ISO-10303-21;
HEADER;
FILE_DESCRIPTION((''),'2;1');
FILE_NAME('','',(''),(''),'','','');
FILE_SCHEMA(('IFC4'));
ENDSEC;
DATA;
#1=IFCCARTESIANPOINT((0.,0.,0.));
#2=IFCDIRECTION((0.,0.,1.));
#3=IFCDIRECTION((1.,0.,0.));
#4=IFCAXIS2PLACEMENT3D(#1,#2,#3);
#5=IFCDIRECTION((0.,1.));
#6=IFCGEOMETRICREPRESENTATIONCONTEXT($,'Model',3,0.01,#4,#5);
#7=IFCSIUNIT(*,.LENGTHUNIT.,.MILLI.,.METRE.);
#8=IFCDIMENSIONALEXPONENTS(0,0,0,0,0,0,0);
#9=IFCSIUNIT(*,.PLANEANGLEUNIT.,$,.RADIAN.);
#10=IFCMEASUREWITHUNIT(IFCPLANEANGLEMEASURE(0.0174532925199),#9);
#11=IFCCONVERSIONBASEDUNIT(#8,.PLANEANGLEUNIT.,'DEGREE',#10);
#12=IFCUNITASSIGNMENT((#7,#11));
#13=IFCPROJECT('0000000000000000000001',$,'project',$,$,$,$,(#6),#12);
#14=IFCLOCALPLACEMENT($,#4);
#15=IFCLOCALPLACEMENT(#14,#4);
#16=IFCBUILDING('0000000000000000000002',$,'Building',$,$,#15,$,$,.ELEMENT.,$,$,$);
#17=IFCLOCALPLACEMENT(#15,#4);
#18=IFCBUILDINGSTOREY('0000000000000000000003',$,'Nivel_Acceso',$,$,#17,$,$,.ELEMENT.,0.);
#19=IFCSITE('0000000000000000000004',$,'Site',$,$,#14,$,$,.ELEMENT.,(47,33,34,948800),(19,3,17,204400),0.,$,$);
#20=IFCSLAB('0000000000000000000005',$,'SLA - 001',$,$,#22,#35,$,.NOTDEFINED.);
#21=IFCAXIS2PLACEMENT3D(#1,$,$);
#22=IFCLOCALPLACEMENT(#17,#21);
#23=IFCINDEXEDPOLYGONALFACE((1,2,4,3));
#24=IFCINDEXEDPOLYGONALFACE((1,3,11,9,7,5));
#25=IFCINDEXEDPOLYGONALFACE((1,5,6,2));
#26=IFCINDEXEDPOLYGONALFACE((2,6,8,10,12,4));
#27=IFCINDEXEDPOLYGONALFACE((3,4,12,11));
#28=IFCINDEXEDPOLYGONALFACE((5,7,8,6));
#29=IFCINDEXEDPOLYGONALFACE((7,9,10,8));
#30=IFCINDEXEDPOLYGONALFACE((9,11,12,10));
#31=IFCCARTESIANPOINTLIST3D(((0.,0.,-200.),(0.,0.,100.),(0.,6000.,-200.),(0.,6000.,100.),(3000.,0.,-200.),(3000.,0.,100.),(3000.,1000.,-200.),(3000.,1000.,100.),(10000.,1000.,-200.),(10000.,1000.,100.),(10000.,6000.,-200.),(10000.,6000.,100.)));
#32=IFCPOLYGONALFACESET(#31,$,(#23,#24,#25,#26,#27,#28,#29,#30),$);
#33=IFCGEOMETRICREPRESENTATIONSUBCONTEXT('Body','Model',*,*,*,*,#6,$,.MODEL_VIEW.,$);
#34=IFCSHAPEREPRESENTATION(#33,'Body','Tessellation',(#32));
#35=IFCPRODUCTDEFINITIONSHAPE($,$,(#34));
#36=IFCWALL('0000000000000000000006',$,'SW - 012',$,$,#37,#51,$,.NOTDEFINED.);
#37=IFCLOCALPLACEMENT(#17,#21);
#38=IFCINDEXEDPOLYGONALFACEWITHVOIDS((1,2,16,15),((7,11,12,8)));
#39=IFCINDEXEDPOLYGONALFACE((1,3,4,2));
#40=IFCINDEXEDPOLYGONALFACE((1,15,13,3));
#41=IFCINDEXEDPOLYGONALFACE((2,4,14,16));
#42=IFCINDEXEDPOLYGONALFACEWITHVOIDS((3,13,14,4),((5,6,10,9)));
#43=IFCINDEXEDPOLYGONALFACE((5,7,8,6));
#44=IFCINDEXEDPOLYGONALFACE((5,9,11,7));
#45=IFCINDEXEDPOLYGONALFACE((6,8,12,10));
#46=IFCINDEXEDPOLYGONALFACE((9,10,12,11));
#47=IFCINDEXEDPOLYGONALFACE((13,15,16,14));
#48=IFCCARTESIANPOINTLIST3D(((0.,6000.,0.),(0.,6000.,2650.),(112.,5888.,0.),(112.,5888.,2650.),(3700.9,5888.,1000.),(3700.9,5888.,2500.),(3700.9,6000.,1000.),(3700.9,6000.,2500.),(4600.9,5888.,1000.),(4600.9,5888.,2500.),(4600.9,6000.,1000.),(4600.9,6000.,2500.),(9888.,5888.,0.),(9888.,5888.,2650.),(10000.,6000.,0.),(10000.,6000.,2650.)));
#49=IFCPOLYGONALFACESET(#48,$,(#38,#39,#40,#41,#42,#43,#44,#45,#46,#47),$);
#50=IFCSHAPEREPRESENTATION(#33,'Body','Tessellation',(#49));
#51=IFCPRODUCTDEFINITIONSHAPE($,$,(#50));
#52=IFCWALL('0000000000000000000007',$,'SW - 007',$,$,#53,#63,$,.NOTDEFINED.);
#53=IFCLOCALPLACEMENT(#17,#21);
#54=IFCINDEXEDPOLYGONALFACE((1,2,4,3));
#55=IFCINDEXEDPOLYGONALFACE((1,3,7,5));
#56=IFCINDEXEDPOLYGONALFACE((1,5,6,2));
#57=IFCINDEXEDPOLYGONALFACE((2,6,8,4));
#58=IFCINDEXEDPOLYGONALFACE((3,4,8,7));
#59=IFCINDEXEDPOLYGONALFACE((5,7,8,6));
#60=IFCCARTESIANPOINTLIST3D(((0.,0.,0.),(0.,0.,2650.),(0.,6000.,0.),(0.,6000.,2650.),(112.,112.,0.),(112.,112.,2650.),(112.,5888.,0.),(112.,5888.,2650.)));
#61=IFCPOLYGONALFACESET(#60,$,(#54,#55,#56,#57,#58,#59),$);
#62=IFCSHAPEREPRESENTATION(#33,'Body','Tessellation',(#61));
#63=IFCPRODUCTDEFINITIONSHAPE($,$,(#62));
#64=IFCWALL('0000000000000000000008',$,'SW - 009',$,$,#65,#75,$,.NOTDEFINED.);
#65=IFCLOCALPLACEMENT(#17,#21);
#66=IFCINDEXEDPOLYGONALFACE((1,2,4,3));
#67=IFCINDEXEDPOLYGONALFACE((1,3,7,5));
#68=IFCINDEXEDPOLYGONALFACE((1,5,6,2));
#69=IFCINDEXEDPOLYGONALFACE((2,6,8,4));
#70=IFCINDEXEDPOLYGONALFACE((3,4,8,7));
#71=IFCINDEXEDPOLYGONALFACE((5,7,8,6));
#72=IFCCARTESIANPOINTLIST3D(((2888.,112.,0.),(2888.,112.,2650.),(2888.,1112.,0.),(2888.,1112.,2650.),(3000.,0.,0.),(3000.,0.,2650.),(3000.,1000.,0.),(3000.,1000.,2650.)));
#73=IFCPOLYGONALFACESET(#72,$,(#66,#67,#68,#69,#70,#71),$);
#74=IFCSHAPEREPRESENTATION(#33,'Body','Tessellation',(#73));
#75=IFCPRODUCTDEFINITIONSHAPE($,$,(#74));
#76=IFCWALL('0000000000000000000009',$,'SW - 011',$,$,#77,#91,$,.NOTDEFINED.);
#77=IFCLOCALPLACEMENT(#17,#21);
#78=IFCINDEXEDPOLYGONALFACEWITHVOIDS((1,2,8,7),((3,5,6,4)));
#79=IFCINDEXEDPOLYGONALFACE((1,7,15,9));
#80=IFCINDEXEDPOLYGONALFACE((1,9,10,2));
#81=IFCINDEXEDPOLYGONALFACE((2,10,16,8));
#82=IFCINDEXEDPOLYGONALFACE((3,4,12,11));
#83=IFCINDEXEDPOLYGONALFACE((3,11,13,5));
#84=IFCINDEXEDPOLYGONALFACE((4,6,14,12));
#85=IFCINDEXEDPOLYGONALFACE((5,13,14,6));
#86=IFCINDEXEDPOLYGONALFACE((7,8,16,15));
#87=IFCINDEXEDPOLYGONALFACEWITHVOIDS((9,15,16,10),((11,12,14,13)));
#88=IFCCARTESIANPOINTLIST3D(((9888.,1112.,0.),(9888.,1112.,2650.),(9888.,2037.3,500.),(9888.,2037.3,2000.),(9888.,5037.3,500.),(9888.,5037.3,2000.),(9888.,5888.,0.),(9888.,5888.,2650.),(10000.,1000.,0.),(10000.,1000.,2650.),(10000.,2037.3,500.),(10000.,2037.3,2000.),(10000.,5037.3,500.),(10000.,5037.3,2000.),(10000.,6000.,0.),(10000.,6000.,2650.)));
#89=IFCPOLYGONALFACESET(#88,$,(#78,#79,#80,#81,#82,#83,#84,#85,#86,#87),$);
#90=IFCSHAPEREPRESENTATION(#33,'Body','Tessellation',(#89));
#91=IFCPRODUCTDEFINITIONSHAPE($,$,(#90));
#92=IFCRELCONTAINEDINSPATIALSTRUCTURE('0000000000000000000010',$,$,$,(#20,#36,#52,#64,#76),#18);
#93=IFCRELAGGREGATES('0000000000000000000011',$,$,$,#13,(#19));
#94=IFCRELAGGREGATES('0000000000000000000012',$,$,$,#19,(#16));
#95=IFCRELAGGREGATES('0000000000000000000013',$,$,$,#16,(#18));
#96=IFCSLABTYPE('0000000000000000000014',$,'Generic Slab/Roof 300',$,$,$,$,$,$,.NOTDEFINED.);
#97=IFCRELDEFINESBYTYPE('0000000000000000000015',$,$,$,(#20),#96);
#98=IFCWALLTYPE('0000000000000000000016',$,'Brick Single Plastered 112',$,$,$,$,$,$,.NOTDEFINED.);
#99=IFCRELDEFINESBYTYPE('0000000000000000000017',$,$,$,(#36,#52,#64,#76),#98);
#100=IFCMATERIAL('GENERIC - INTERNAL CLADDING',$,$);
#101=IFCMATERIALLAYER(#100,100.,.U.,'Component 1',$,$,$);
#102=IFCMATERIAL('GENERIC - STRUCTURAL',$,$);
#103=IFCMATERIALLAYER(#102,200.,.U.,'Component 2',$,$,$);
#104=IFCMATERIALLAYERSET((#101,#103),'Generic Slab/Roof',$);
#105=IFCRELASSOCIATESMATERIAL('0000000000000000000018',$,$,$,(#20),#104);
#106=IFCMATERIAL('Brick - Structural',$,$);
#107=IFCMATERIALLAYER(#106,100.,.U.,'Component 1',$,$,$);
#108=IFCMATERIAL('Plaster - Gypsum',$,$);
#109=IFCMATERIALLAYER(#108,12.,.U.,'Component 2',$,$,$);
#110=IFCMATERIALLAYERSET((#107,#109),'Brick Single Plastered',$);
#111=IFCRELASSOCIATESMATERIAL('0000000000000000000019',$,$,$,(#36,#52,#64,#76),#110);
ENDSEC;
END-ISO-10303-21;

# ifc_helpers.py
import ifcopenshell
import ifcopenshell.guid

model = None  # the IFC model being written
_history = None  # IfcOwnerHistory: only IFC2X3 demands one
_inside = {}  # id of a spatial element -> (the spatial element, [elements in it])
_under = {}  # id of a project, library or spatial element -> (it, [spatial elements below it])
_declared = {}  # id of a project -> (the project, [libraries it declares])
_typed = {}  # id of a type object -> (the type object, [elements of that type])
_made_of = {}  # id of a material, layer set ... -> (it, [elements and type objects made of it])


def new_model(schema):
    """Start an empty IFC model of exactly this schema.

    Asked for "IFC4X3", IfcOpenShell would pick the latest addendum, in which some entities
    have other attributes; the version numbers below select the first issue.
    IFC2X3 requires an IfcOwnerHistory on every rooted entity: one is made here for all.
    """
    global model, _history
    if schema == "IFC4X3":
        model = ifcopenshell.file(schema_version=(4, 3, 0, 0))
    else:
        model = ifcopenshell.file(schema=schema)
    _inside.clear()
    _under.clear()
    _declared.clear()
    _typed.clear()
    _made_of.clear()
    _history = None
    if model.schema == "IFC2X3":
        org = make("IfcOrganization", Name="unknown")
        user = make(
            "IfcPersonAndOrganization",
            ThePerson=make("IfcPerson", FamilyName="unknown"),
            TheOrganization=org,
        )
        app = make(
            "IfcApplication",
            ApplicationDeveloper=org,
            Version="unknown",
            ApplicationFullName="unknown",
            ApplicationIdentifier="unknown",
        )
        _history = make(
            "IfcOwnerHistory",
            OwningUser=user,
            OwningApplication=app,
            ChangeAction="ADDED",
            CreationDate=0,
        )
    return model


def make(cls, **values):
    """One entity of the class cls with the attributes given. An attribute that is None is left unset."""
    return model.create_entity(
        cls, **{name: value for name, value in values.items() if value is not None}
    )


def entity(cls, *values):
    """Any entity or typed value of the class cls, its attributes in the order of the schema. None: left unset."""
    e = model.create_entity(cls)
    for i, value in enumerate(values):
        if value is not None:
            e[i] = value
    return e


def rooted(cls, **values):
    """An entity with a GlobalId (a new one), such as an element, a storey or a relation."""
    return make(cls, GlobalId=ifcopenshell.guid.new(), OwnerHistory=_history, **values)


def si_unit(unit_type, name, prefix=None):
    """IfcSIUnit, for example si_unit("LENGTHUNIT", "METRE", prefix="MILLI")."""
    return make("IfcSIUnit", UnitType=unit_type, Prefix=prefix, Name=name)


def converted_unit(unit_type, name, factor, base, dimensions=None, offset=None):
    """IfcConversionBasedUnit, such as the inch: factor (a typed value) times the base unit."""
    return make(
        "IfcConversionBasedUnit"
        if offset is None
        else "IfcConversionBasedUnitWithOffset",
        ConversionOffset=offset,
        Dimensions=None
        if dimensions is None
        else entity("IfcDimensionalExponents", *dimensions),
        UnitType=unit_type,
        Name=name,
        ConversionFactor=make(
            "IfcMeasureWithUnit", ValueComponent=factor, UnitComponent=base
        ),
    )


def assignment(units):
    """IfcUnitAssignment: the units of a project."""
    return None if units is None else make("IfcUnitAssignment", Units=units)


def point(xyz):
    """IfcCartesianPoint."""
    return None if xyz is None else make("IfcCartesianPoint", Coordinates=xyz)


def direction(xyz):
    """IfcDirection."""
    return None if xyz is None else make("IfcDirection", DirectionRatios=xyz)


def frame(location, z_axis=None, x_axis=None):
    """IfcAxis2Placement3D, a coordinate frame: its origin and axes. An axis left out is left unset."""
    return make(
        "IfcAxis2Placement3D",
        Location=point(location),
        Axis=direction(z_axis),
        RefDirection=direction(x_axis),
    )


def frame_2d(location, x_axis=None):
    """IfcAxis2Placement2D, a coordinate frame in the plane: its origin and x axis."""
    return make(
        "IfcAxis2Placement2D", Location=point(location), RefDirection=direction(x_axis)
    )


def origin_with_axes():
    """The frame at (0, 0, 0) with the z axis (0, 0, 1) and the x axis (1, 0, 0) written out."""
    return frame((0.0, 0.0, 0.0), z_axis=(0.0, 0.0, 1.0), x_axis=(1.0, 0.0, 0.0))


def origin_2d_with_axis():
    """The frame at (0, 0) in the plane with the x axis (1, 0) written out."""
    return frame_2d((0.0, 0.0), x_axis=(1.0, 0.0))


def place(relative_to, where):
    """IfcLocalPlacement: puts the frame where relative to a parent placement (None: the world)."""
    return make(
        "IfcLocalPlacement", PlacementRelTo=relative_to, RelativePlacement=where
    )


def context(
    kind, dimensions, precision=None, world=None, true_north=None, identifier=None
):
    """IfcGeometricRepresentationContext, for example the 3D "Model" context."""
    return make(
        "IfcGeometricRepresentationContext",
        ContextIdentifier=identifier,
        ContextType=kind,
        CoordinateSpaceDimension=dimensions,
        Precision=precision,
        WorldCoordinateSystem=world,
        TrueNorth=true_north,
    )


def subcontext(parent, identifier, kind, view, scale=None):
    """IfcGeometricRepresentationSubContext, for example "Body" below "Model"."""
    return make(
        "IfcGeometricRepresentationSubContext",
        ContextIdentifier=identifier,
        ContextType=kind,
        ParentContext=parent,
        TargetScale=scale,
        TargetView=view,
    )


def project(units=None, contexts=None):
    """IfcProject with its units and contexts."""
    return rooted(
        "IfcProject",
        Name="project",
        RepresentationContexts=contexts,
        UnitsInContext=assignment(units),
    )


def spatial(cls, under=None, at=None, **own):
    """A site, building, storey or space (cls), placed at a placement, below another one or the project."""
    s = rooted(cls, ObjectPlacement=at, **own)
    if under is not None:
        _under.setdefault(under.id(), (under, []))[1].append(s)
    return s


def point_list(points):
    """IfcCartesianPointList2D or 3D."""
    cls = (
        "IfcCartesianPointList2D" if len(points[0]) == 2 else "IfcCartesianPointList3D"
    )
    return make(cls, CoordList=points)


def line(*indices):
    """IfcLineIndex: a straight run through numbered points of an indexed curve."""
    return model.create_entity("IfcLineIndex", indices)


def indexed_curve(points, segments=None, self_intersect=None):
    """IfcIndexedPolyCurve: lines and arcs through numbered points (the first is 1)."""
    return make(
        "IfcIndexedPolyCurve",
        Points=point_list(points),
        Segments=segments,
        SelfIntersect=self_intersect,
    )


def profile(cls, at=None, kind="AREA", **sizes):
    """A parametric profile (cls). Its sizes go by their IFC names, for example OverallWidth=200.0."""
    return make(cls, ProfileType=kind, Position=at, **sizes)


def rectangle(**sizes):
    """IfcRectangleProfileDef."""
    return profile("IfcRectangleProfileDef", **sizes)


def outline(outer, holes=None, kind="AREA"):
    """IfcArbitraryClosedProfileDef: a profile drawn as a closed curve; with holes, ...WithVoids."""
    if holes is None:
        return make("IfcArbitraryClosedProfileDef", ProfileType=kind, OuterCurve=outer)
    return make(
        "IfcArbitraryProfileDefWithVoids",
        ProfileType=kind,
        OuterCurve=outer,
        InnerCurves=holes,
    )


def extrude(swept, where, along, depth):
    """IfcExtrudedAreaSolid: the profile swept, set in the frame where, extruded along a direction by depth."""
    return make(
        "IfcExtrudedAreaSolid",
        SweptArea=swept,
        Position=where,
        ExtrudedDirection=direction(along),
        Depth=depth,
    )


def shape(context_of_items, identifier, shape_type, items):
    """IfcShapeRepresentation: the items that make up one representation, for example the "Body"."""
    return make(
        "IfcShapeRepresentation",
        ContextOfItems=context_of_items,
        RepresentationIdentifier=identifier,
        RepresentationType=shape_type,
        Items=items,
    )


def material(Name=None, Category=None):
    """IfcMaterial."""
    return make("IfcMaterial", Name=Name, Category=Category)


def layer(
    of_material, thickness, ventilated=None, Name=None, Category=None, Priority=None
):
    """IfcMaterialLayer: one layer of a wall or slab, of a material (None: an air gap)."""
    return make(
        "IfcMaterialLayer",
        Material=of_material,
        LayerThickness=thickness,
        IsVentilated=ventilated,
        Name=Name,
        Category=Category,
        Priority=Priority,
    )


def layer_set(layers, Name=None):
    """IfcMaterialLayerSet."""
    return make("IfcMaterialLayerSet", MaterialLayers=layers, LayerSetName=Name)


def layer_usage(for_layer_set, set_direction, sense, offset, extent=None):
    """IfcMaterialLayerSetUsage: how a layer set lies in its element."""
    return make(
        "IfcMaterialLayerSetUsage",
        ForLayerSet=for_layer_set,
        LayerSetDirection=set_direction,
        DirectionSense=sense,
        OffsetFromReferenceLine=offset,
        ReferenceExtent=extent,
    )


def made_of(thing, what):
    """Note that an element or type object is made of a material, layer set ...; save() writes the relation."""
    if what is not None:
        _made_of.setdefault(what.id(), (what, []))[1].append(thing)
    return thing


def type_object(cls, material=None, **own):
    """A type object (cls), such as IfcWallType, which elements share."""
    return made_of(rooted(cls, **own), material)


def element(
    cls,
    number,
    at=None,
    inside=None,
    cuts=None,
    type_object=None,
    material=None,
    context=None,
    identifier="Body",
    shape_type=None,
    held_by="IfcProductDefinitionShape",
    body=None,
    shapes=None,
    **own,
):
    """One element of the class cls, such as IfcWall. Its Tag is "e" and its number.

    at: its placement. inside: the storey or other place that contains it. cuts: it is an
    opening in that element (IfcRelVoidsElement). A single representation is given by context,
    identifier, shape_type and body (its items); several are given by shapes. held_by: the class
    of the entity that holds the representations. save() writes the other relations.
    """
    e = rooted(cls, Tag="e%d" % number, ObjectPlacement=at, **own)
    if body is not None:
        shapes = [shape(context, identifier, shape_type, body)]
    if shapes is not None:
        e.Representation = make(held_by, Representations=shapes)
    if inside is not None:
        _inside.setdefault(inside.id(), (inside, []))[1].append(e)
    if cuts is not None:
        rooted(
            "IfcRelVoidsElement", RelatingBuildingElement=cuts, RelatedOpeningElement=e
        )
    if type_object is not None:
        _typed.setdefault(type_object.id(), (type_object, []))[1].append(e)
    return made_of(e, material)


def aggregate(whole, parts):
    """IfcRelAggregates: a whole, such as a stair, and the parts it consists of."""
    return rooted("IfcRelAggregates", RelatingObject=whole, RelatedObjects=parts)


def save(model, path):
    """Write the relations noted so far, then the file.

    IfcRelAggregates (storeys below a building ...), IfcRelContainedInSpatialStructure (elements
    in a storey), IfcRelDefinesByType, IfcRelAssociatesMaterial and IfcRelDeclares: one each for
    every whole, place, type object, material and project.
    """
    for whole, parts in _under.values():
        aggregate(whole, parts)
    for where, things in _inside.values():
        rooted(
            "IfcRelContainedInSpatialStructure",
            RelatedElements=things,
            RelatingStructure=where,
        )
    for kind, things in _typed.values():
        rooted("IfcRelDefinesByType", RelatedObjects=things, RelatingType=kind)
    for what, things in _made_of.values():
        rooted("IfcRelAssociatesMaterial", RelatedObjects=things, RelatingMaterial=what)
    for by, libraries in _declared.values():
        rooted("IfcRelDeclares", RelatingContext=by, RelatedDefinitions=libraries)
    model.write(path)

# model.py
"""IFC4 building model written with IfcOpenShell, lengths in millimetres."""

from ifc_helpers import new_model, entity, si_unit, converted_unit, direction, frame, origin_with_axes, origin_2d_with_axis, place, context, subcontext, project, spatial, line, indexed_curve, rectangle, outline, extrude, material, layer, layer_set, layer_usage, type_object, element, save


model = new_model("IFC4")

# Units and contexts
model_context = context("Model", 3, precision=0.01, world=origin_with_axes(), true_north=direction((0.0, 1.0)))
body_context = subcontext(model_context, "Body", "Model", "MODEL_VIEW")
ifc_project = project(units=[si_unit("LENGTHUNIT", "METRE", prefix="MILLI"), converted_unit("PLANEANGLEUNIT", "DEGREE", entity("IfcPlaneAngleMeasure", 0.0174532925199), si_unit("PLANEANGLEUNIT", "RADIAN"), dimensions=[0, 0, 0, 0, 0, 0, 0])], contexts=[model_context])

# Site, building, storey
site_placement = place(None, origin_with_axes())
site = spatial("IfcSite", under=ifc_project, at=site_placement, Name="Site", CompositionType="ELEMENT", RefLatitude=(47, 33, 34, 948800), RefLongitude=(19, 3, 17, 204400), RefElevation=0.0)
building_placement = place(site_placement, origin_with_axes())
building = spatial("IfcBuilding", under=site, at=building_placement, Name="Building", CompositionType="ELEMENT")
storey_placement = place(building_placement, origin_with_axes())
storey = spatial("IfcBuildingStorey", under=building, at=storey_placement, Name="Nivel_Acceso", CompositionType="ELEMENT", Elevation=0.0)

# Slab
ifc_material_1 = material(Name="GENERIC - INTERNAL CLADDING")
ifc_layer_1 = layer(ifc_material_1, 100.0, ventilated="UNKNOWN", Name="Component 1")
ifc_material_2 = material(Name="GENERIC - STRUCTURAL")
ifc_layer_2 = layer(ifc_material_2, 200.0, ventilated="UNKNOWN", Name="Component 2")
ifc_layer_set_1 = layer_set([ifc_layer_1, ifc_layer_2], Name="Generic Slab/Roof")
ifc_layer_usage_1 = layer_usage(ifc_layer_set_1, "AXIS3", "NEGATIVE", 300.0)
slab_type = type_object("IfcSlabType", Name="Generic Slab/Roof 300", PredefinedType="NOTDEFINED")
slab_placement = place(storey_placement, origin_with_axes())
element("IfcSlab", 1, at=slab_placement, inside=storey, type_object=slab_type, material=ifc_layer_usage_1, Name="SLA - 001", PredefinedType="NOTDEFINED", context=body_context, shape_type="SweptSolid", body=[
    extrude(outline(indexed_curve([(0.0, 0.0), (3000.0, 0.0), (3000.0, 1000.0), (10000.0, 1000.0), (10000.0, 6000.0), (0.0, 6000.0)], segments=[line(1, 2, 3, 4, 5, 6, 1)])), frame((0.0, 0.0, -200.0), z_axis=(0.0, 0.0, 1.0), x_axis=(1.0, 0.0, 0.0)), (0.0, 0.0, 1.0), 300.0),
])

# Wall, opening
ifc_material_3 = material(Name="Brick - Structural")
ifc_layer_3 = layer(ifc_material_3, 100.0, ventilated="UNKNOWN", Name="Component 1")
ifc_material_4 = material(Name="Plaster - Gypsum")
ifc_layer_4 = layer(ifc_material_4, 12.0, ventilated="UNKNOWN", Name="Component 2")
ifc_layer_set_2 = layer_set([ifc_layer_3, ifc_layer_4], Name="Brick Single Plastered")
ifc_layer_usage_2 = layer_usage(ifc_layer_set_2, "AXIS2", "POSITIVE", 0.0)
wall_type = type_object("IfcWallType", Name="Brick Single Plastered 112", PredefinedType="NOTDEFINED")
wall_1_placement = place(storey_placement, frame((10000.0, 6000.0, 0.0), z_axis=(0.0, 0.0, 1.0), x_axis=(-1.0, 0.0, 0.0)))
wall_1 = element("IfcWall", 2, at=wall_1_placement, inside=storey, type_object=wall_type, material=ifc_layer_usage_2, Name="SW - 012", PredefinedType="NOTDEFINED", context=body_context, shape_type="SweptSolid", body=[
    extrude(outline(indexed_curve([(0.0, 0.0), (10000.0, 0.0), (9888.0, 112.0), (112.0, 112.0)], segments=[line(1, 2, 3, 4, 1)])), origin_with_axes(), (0.0, 0.0, 1.0), 2650.0),
])
opening_1_placement = place(wall_1_placement, frame((5849.1, 0.0, 1000.0), z_axis=(0.0, 0.0, 1.0), x_axis=(1.0, 0.0, 0.0)))
element("IfcOpeningElement", 3, at=opening_1_placement, cuts=wall_1, context=body_context, shape_type="SweptSolid", body=[
    extrude(rectangle(XDim=900.0, YDim=1500.0, at=origin_2d_with_axis()), frame((0.0, 112.0, 750.0), z_axis=(0.0, -1.0, 0.0), x_axis=(-1.0, 0.0, 0.0)), (0.0, 0.0, 1.0), 336.0),
])

# Wall
ifc_layer_usage_3 = layer_usage(ifc_layer_set_2, "AXIS2", "POSITIVE", 0.0)
wall_2_placement = place(storey_placement, frame((0.0, 6000.0, 0.0), z_axis=(0.0, 0.0, 1.0), x_axis=(0.0, -1.0, 0.0)))
element("IfcWall", 4, at=wall_2_placement, inside=storey, type_object=wall_type, material=ifc_layer_usage_3, Name="SW - 007", PredefinedType="NOTDEFINED", context=body_context, shape_type="SweptSolid", body=[
    extrude(outline(indexed_curve([(0.0, 0.0), (6000.0, 0.0), (5888.0, 112.0), (112.0, 112.0)], segments=[line(1, 2, 3, 4, 1)])), origin_with_axes(), (0.0, 0.0, 1.0), 2650.0),
])

# Wall
ifc_layer_usage_4 = layer_usage(ifc_layer_set_2, "AXIS2", "POSITIVE", 0.0)
wall_3_placement = place(storey_placement, frame((3000.0, 0.0, 0.0), z_axis=(0.0, 0.0, 1.0), x_axis=(0.0, 1.0, 0.0)))
element("IfcWall", 5, at=wall_3_placement, inside=storey, type_object=wall_type, material=ifc_layer_usage_4, Name="SW - 009", PredefinedType="NOTDEFINED", context=body_context, shape_type="SweptSolid", body=[
    extrude(outline(indexed_curve([(0.0, 0.0), (1000.0, 0.0), (1112.0, 112.0), (112.0, 112.0)], segments=[line(1, 2, 3, 4, 1)])), origin_with_axes(), (0.0, 0.0, 1.0), 2650.0),
])

# Wall, opening
ifc_layer_usage_5 = layer_usage(ifc_layer_set_2, "AXIS2", "POSITIVE", 0.0)
wall_4_placement = place(storey_placement, frame((10000.0, 1000.0, 0.0), z_axis=(0.0, 0.0, 1.0), x_axis=(0.0, 1.0, 0.0)))
wall_4 = element("IfcWall", 6, at=wall_4_placement, inside=storey, type_object=wall_type, material=ifc_layer_usage_5, Name="SW - 011", PredefinedType="NOTDEFINED", context=body_context, shape_type="SweptSolid", body=[
    extrude(outline(indexed_curve([(0.0, 0.0), (5000.0, 0.0), (4888.0, 112.0), (112.0, 112.0)], segments=[line(1, 2, 3, 4, 1)])), origin_with_axes(), (0.0, 0.0, 1.0), 2650.0),
])
opening_2_placement = place(wall_4_placement, frame((2537.3, 0.0, 500.0), z_axis=(0.0, 0.0, 1.0), x_axis=(1.0, 0.0, 0.0)))
element("IfcOpeningElement", 7, at=opening_2_placement, cuts=wall_4, context=body_context, shape_type="SweptSolid", body=[
    extrude(rectangle(XDim=3000.0, YDim=1500.0, at=origin_2d_with_axis()), frame((0.0, 112.0, 750.0), z_axis=(0.0, -1.0, 0.0), x_axis=(-1.0, 0.0, 0.0)), (0.0, 0.0, 1.0), 336.0),
])

save(model, "model.ifc")
